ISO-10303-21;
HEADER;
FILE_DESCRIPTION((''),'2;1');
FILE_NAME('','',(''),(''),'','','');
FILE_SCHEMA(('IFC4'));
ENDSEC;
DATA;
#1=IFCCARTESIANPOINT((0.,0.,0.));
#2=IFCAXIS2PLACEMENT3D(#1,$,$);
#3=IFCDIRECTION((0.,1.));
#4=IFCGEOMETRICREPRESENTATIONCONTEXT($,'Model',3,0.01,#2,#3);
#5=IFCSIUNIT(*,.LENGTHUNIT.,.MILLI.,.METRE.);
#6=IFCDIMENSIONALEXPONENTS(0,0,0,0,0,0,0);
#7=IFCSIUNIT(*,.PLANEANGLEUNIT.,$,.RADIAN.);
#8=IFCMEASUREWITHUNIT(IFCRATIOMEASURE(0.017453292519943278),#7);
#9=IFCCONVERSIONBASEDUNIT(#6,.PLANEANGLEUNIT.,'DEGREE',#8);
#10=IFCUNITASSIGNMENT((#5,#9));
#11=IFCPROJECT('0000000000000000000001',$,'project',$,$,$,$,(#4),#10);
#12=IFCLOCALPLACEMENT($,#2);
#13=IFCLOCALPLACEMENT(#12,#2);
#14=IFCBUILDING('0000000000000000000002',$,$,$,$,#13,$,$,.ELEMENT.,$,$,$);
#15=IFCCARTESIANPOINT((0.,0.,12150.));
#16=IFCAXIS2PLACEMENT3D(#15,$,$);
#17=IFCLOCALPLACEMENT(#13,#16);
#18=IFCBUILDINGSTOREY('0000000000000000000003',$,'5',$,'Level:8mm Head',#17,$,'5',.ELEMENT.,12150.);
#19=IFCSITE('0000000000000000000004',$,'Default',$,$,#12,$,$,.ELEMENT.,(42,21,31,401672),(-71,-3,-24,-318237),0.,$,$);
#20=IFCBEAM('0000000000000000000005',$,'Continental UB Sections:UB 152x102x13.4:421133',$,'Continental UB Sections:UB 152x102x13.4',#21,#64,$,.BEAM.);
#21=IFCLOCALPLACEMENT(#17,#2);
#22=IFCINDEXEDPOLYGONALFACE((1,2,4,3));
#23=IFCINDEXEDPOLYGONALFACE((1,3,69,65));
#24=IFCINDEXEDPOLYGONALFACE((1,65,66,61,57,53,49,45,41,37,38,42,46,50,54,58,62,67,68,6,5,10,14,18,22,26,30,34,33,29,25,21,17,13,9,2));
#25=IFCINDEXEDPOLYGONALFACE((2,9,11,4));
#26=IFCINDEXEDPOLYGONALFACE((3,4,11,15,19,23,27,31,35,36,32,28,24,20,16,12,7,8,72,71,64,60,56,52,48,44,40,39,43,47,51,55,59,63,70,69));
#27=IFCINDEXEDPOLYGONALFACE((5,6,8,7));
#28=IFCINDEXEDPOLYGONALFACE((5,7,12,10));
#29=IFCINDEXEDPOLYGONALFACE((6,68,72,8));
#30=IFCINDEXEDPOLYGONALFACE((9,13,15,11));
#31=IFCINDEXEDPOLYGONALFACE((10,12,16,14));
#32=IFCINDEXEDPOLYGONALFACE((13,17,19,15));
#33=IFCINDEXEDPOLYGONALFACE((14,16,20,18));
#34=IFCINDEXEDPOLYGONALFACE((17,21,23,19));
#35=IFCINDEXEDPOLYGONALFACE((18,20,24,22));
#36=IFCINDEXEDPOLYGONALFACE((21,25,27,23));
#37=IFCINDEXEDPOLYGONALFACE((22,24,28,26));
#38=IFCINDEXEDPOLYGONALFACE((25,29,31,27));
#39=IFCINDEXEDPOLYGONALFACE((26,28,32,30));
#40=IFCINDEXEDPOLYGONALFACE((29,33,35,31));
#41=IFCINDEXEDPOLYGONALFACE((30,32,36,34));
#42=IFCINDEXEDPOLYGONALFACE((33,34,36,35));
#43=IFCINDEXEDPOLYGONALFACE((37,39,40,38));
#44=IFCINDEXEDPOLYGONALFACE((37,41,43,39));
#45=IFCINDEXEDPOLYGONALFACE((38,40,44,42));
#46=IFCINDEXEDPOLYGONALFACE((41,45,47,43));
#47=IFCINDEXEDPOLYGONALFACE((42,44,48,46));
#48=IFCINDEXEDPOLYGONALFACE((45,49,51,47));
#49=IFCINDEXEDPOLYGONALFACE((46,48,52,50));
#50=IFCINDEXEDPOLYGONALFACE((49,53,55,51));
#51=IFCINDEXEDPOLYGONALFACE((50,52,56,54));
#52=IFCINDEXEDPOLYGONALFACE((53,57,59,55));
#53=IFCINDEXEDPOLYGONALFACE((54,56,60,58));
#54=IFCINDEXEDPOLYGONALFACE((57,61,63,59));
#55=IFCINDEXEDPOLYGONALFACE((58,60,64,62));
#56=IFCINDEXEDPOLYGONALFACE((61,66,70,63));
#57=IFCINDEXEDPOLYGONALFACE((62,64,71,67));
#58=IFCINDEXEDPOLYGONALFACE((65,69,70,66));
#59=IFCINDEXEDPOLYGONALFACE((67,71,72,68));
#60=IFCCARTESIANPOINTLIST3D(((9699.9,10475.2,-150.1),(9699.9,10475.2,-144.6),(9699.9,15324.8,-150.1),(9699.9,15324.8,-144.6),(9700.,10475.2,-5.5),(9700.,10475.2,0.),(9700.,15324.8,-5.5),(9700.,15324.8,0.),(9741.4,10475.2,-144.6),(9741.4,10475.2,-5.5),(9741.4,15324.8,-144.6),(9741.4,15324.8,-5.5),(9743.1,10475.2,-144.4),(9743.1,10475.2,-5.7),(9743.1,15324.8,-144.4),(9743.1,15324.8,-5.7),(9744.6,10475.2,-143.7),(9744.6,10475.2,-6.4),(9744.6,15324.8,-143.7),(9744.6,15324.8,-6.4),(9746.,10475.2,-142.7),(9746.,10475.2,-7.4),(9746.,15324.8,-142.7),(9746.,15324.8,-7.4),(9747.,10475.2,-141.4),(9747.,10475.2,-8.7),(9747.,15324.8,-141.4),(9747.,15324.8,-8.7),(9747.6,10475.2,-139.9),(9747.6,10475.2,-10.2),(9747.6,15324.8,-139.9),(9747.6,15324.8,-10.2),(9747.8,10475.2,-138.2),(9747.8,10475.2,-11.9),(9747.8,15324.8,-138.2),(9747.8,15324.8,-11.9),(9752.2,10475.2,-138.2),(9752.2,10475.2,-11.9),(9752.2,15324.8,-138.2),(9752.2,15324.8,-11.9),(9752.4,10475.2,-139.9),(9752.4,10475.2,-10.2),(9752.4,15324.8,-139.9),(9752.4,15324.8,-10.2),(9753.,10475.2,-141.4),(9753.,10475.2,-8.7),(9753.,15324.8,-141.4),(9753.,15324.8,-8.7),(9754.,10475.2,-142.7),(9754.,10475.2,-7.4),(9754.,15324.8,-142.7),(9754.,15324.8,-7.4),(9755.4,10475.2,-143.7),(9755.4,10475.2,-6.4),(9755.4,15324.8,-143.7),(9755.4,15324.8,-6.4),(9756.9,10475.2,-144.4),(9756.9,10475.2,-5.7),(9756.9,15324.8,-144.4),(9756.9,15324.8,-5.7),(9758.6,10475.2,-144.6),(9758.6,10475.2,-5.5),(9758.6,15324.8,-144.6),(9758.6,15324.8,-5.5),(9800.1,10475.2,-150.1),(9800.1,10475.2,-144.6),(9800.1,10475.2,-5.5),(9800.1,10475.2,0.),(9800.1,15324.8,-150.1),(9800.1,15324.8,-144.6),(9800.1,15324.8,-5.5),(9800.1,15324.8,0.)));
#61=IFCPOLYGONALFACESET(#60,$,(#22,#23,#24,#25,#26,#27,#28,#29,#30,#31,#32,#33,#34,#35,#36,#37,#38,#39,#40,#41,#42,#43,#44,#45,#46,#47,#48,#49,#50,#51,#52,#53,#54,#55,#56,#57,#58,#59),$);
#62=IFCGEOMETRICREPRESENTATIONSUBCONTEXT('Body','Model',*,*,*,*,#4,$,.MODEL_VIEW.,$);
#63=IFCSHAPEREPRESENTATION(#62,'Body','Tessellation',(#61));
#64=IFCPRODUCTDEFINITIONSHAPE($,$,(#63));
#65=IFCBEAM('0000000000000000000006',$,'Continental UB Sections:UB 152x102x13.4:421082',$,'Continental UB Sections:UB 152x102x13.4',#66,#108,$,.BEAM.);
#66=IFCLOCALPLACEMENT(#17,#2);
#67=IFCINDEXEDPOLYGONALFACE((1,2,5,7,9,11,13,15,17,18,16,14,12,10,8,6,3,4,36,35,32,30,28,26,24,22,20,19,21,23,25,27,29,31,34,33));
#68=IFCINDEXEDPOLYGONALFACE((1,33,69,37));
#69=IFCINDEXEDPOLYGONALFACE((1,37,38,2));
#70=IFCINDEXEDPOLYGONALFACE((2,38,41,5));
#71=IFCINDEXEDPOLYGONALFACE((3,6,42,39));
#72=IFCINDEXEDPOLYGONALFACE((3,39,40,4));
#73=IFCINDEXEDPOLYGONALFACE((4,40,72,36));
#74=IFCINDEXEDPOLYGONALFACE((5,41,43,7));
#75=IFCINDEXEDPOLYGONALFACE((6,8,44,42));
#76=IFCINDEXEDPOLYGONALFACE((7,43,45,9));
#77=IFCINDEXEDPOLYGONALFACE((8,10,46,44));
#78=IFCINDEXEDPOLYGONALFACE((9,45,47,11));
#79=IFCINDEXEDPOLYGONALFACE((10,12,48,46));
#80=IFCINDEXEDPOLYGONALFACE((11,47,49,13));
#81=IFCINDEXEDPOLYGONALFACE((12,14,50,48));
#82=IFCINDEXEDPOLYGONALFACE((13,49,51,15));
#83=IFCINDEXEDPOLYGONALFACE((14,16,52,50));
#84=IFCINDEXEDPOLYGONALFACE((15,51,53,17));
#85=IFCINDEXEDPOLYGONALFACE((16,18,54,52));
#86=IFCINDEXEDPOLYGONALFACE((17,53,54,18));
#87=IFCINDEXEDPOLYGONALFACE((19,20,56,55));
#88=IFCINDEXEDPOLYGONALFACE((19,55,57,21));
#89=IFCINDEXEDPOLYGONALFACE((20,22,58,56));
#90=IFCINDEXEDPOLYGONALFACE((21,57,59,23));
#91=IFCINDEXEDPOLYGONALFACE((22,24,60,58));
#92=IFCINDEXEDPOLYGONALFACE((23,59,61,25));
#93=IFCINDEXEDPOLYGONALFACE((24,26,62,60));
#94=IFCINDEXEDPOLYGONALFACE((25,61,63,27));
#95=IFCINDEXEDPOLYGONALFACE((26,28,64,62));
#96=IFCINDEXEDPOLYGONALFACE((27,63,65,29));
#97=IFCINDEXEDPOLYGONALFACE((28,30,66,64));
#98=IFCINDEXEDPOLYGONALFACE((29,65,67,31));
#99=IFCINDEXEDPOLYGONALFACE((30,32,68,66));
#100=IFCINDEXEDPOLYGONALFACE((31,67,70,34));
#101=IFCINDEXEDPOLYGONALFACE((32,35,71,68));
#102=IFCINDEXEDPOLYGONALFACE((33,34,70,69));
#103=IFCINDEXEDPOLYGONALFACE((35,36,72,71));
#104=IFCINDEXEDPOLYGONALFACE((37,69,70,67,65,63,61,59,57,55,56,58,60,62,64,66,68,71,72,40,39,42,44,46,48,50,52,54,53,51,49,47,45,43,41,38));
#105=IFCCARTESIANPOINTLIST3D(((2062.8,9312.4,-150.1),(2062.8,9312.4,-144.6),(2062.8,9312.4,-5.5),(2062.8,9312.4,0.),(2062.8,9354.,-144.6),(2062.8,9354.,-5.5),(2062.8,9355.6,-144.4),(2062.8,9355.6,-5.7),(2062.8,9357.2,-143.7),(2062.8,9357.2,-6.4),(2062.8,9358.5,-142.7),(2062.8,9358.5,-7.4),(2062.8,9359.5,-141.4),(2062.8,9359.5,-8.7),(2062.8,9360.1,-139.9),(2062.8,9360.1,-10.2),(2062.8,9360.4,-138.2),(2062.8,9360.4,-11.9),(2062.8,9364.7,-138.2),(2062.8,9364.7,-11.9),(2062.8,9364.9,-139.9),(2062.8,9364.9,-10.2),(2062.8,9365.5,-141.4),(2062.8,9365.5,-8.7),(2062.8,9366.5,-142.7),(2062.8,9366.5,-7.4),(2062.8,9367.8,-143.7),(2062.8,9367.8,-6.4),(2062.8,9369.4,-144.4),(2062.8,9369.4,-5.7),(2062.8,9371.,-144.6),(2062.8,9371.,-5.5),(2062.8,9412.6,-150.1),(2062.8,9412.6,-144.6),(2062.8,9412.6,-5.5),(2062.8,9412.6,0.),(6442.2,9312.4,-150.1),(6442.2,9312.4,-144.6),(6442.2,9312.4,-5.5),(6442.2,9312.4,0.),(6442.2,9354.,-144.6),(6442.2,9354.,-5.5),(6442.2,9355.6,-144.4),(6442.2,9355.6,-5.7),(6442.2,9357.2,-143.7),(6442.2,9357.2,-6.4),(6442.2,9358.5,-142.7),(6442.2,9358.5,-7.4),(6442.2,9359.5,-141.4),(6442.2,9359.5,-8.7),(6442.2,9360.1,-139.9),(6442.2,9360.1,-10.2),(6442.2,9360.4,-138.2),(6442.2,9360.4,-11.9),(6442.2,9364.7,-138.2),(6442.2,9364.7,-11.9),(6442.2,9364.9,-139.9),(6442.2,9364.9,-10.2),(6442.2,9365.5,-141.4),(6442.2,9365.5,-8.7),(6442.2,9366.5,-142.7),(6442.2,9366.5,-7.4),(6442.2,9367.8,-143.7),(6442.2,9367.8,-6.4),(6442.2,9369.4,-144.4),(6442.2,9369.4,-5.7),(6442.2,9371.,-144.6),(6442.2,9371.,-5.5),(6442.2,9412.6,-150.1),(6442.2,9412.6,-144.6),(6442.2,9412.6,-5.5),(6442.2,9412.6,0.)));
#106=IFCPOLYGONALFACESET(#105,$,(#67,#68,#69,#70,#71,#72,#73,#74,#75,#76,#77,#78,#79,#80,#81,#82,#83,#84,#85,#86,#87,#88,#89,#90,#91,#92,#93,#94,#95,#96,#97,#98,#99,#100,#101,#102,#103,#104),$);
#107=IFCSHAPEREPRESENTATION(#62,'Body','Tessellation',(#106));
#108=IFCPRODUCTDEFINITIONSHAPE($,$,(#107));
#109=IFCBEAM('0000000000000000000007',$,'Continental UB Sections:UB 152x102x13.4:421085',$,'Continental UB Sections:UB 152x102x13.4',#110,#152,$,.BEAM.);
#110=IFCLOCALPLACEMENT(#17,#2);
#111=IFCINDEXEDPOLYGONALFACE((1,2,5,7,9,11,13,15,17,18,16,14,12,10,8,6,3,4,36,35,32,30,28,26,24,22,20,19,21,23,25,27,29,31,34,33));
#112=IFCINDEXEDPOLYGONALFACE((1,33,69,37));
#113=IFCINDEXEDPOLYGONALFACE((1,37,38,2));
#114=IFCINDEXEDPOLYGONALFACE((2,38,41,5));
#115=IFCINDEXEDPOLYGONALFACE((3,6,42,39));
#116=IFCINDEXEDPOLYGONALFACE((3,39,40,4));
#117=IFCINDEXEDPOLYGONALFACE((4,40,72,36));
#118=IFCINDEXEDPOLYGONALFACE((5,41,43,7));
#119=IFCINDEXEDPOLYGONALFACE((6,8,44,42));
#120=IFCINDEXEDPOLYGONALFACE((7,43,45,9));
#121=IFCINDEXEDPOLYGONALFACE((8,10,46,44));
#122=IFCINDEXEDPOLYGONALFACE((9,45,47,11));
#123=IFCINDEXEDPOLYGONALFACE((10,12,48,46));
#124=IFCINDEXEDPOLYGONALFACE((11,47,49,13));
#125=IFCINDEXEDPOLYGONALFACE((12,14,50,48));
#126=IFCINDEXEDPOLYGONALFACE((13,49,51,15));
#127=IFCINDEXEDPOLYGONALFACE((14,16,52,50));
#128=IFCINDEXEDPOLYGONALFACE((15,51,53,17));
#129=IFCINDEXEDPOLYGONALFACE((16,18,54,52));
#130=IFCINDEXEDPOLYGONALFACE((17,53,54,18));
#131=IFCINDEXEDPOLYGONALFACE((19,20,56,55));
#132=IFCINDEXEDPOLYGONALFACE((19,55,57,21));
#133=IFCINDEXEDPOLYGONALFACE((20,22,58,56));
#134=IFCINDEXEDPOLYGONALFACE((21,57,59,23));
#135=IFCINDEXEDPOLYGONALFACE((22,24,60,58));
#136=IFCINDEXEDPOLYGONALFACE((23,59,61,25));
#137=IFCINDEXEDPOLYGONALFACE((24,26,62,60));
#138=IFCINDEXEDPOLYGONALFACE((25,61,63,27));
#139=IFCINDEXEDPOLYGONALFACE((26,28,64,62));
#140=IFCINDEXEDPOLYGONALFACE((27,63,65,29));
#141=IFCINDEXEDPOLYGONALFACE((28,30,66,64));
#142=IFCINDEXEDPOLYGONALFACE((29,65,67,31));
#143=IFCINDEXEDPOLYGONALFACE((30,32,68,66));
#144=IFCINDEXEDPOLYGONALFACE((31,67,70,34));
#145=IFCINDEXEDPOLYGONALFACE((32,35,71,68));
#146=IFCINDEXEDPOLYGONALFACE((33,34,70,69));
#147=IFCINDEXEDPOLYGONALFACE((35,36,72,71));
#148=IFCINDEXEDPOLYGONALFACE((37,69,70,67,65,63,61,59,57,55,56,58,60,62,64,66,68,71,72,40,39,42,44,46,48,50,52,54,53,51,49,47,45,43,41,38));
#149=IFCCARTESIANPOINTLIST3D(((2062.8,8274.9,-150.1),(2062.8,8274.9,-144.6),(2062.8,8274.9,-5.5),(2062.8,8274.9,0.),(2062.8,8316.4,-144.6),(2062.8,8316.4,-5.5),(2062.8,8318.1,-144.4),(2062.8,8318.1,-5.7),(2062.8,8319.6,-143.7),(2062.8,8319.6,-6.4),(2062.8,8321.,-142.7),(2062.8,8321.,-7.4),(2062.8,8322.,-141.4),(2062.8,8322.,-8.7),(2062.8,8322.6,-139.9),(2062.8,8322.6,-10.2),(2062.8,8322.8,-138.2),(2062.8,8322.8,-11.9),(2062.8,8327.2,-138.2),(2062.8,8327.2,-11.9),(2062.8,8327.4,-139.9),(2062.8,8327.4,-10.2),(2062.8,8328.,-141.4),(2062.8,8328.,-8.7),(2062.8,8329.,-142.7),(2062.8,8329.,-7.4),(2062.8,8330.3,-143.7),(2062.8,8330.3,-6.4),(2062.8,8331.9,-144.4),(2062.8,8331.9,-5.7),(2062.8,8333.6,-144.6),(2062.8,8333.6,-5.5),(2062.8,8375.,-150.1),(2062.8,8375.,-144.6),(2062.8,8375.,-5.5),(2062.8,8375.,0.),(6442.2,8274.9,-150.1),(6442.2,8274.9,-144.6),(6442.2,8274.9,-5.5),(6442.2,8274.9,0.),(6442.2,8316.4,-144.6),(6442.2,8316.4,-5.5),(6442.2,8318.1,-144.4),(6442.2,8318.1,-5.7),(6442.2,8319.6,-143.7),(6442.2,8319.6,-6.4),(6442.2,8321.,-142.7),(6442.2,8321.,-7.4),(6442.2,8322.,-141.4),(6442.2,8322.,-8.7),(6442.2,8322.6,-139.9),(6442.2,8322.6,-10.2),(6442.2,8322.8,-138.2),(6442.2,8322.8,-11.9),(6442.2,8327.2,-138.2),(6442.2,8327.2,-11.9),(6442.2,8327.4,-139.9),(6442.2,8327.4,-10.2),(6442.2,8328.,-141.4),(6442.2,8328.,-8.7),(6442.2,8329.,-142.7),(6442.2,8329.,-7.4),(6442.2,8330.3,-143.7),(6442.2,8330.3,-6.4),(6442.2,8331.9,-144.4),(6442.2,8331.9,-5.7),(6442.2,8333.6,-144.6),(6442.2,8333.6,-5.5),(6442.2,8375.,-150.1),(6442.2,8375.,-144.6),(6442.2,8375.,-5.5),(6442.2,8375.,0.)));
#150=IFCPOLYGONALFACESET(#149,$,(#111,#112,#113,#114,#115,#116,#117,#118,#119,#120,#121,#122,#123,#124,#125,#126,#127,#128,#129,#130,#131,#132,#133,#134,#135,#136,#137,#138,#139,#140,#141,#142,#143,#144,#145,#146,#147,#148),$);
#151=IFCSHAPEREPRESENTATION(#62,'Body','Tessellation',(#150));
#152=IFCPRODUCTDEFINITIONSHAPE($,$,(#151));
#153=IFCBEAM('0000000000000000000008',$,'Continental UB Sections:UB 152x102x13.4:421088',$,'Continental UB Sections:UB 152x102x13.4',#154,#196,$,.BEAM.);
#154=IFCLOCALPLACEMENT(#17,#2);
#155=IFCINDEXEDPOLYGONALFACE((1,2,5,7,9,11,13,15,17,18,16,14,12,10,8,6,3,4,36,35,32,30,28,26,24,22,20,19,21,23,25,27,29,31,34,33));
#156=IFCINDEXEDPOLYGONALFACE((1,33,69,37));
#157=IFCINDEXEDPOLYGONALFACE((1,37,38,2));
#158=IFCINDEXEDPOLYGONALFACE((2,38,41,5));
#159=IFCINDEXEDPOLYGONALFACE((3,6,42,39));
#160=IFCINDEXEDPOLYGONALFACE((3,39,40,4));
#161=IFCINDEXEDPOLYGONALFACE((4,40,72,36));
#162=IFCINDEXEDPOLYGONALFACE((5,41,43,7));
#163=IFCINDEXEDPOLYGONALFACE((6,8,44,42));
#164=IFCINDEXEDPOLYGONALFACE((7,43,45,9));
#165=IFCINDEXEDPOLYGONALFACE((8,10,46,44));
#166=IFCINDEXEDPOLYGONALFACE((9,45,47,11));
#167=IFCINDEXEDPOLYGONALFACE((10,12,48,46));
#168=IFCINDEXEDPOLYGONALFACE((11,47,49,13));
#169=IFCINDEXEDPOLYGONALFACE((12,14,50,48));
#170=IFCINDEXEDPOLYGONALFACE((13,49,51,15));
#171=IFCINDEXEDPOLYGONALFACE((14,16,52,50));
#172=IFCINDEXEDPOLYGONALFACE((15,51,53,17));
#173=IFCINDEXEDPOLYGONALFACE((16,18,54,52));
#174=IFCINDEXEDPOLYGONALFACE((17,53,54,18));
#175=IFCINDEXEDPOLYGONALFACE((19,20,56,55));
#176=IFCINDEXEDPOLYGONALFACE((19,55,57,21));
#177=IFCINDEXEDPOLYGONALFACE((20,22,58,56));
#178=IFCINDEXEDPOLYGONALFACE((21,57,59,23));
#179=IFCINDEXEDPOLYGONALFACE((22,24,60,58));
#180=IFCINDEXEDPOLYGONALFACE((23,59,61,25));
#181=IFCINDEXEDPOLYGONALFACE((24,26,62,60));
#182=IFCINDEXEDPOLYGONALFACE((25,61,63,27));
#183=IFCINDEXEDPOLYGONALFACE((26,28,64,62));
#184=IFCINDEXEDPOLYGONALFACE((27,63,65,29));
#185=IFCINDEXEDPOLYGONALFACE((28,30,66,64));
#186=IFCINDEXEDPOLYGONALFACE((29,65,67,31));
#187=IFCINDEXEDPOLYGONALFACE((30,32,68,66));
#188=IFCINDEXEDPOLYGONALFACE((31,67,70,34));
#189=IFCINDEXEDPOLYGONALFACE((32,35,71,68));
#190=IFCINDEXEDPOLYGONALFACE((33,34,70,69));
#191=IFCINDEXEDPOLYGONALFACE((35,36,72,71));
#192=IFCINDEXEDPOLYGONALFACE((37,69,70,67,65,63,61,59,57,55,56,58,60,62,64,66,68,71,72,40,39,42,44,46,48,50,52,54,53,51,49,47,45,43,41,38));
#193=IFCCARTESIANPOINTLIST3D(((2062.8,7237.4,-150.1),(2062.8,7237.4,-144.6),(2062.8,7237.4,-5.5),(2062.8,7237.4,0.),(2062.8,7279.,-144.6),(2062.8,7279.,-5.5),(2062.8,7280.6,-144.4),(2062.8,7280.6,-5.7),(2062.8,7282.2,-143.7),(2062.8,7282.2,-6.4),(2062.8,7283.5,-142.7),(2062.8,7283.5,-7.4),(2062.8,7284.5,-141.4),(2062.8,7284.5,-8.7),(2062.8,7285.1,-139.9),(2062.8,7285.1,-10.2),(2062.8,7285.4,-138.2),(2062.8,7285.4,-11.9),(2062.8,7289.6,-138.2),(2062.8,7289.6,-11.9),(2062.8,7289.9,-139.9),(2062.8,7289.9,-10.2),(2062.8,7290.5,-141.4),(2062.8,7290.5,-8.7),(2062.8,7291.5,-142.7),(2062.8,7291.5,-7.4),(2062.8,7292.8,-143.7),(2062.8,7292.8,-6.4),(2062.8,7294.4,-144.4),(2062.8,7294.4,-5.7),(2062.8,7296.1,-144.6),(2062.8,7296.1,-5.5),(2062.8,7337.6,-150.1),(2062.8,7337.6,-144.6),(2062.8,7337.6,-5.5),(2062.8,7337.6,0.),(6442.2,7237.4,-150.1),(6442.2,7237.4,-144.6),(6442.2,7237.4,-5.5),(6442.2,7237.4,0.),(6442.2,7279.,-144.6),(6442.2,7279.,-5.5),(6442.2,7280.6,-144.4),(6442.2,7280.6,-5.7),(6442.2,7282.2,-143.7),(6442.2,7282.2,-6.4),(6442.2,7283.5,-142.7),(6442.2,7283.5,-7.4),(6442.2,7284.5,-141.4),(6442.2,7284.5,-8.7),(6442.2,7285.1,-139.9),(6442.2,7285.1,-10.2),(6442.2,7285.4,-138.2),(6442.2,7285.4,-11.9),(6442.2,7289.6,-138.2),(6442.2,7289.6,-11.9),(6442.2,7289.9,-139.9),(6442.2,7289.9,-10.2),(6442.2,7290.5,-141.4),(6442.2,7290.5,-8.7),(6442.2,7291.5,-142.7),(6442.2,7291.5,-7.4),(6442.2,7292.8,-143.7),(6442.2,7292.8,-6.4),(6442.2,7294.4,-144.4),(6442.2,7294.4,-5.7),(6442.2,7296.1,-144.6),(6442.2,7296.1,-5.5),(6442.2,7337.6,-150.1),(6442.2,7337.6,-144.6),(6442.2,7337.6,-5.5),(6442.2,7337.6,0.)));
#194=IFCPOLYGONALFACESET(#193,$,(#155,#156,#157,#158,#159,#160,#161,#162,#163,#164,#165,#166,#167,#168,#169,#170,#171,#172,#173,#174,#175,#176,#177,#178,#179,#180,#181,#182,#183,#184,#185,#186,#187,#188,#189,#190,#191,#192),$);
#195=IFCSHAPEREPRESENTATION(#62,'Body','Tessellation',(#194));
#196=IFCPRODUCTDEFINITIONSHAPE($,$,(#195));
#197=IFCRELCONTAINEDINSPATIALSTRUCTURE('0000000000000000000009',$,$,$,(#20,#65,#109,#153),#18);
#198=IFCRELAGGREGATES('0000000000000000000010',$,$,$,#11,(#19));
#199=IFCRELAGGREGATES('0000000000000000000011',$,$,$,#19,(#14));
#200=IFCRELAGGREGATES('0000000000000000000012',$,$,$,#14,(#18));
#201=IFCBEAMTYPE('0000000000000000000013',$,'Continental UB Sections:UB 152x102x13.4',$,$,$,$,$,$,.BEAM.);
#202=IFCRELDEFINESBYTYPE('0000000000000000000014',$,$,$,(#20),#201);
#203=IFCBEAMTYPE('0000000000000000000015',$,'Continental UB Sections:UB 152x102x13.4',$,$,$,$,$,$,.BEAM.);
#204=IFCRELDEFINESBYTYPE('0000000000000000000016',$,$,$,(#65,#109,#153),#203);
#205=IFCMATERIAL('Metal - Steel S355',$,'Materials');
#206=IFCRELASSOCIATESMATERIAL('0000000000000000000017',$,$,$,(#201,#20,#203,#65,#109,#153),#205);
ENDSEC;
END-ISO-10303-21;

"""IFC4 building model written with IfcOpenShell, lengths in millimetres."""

from ifc_helpers import new_model, entity, si_unit, converted_unit, direction, frame, origin, place, context, subcontext, project, spatial, line, arc, indexed_curve, outline, extrude, source, transform, mapped, material, type_object, type_shapes, element, save


model = new_model("IFC4")

# Units and contexts
model_context = context("Model", 3, precision=0.01, world=origin(), true_north=direction((0.0, 1.0)))
body_context = subcontext(model_context, "Body", "Model", "MODEL_VIEW")
ifc_project = project(units=[si_unit("LENGTHUNIT", "METRE", prefix="MILLI"), converted_unit("PLANEANGLEUNIT", "DEGREE", entity("IfcRatioMeasure", 0.017453292519943278), si_unit("PLANEANGLEUNIT", "RADIAN"), dimensions=[0, 0, 0, 0, 0, 0, 0])], contexts=[model_context])

# Site, building, storey
site_placement = place(None, origin())
site = spatial("IfcSite", under=ifc_project, at=site_placement, Name="Default", CompositionType="ELEMENT", RefLatitude=(42, 21, 31, 401672), RefLongitude=(-71, -3, -24, -318237), RefElevation=0.0)
building_placement = place(site_placement, origin())
building = spatial("IfcBuilding", under=site, at=building_placement, CompositionType="ELEMENT")
storey_placement = place(building_placement, frame((0.0, 0.0, 12150.0)))
storey = spatial("IfcBuildingStorey", under=building, at=storey_placement, Name="5", ObjectType="Level:8mm Head", LongName="5", CompositionType="ELEMENT", Elevation=12150.0)

# Beams
ifc_material = material(Name="Metal - Steel S355", Category="Materials")
beam_type_1 = type_object("IfcBeamType", Name="Continental UB Sections:UB 152x102x13.4", PredefinedType="BEAM", material=ifc_material)
shared_shape_1 = source(origin(), body_context, "Body", "SweptSolid", [
    extrude(outline(indexed_curve([(-75.0, -50.1), (-69.6, -50.1), (-69.6, -8.5), (-67.7, -4.0), (-63.2, -2.1), (63.1, -2.1), (67.7, -4.0), (69.5, -8.5), (69.5, -50.1), (75.1, -50.1), (75.1, 50.1), (69.5, 50.1), (69.5, 8.6), (67.7, 4.0), (63.1, 2.2), (-63.2, 2.2), (-67.7, 4.0), (-69.6, 8.6), (-69.6, 50.0), (-75.0, 50.0)], segments=[line(1, 2, 3), arc(3, 4, 5), line(5, 6), arc(6, 7, 8), line(8, 9, 10, 11, 12, 13), arc(13, 14, 15), line(15, 16), arc(16, 17, 18), line(18, 19, 20, 1)], self_intersect=False)), frame((-2424.8, 0.0, 0.0), z_axis=(1.0, 0.0, 0.0), x_axis=(0.0, 0.0, -1.0)), (0.0, 0.0, 1.0), 4849.6),
])
type_shapes(beam_type_1, [shared_shape_1])
for number, where, z_axis, x_axis, name in (
    (1, (9750.0, 12900.0, -75.1), (0.0, 0.0, 1.0), (0.0, 1.0, 0.0), "Continental UB Sections:UB 152x102x13.4:421133"),
):
    element("IfcBeam", number, at=place(storey_placement, frame(where, z_axis=z_axis, x_axis=x_axis)), inside=storey, type_object=beam_type_1, material=ifc_material, Name=name, ObjectType="Continental UB Sections:UB 152x102x13.4", PredefinedType="BEAM", context=body_context, shape_type="MappedRepresentation", body=[
        mapped(shared_shape_1, transform((0.0, 0.0, 0.0), scale=1.0)),
    ])
beam_type_2 = type_object("IfcBeamType", Name="Continental UB Sections:UB 152x102x13.4", PredefinedType="BEAM", material=ifc_material)
shared_shape_2 = source(origin(), body_context, "Body", "SweptSolid", [
    extrude(outline(indexed_curve([(-75.0, -50.1), (-69.6, -50.1), (-69.6, -8.5), (-67.7, -4.0), (-63.2, -2.1), (63.1, -2.1), (67.7, -4.0), (69.5, -8.5), (69.5, -50.1), (75.1, -50.1), (75.1, 50.1), (69.5, 50.1), (69.5, 8.6), (67.7, 4.0), (63.1, 2.2), (-63.2, 2.2), (-67.7, 4.0), (-69.6, 8.6), (-69.6, 50.0), (-75.0, 50.0)], segments=[line(1, 2, 3), arc(3, 4, 5), line(5, 6), arc(6, 7, 8), line(8, 9, 10, 11, 12, 13), arc(13, 14, 15), line(15, 16), arc(16, 17, 18), line(18, 19, 20, 1)], self_intersect=False)), frame((-2189.7, 0.0, 0.0), z_axis=(1.0, 0.0, 0.0), x_axis=(0.0, 0.0, -1.0)), (0.0, 0.0, 1.0), 4379.4),
])
type_shapes(beam_type_2, [shared_shape_2])
for number, where, name in (
    (2, (4252.5, 9362.5, -75.1), "Continental UB Sections:UB 152x102x13.4:421082"),
    (3, (4252.5, 8325.0, -75.1), "Continental UB Sections:UB 152x102x13.4:421085"),
    (4, (4252.5, 7287.5, -75.1), "Continental UB Sections:UB 152x102x13.4:421088"),
):
    element("IfcBeam", number, at=place(storey_placement, frame(where)), inside=storey, type_object=beam_type_2, material=ifc_material, Name=name, ObjectType="Continental UB Sections:UB 152x102x13.4", PredefinedType="BEAM", context=body_context, shape_type="MappedRepresentation", body=[
        mapped(shared_shape_2, transform((0.0, 0.0, 0.0), scale=1.0)),
    ])

save(model, "model.ifc")
